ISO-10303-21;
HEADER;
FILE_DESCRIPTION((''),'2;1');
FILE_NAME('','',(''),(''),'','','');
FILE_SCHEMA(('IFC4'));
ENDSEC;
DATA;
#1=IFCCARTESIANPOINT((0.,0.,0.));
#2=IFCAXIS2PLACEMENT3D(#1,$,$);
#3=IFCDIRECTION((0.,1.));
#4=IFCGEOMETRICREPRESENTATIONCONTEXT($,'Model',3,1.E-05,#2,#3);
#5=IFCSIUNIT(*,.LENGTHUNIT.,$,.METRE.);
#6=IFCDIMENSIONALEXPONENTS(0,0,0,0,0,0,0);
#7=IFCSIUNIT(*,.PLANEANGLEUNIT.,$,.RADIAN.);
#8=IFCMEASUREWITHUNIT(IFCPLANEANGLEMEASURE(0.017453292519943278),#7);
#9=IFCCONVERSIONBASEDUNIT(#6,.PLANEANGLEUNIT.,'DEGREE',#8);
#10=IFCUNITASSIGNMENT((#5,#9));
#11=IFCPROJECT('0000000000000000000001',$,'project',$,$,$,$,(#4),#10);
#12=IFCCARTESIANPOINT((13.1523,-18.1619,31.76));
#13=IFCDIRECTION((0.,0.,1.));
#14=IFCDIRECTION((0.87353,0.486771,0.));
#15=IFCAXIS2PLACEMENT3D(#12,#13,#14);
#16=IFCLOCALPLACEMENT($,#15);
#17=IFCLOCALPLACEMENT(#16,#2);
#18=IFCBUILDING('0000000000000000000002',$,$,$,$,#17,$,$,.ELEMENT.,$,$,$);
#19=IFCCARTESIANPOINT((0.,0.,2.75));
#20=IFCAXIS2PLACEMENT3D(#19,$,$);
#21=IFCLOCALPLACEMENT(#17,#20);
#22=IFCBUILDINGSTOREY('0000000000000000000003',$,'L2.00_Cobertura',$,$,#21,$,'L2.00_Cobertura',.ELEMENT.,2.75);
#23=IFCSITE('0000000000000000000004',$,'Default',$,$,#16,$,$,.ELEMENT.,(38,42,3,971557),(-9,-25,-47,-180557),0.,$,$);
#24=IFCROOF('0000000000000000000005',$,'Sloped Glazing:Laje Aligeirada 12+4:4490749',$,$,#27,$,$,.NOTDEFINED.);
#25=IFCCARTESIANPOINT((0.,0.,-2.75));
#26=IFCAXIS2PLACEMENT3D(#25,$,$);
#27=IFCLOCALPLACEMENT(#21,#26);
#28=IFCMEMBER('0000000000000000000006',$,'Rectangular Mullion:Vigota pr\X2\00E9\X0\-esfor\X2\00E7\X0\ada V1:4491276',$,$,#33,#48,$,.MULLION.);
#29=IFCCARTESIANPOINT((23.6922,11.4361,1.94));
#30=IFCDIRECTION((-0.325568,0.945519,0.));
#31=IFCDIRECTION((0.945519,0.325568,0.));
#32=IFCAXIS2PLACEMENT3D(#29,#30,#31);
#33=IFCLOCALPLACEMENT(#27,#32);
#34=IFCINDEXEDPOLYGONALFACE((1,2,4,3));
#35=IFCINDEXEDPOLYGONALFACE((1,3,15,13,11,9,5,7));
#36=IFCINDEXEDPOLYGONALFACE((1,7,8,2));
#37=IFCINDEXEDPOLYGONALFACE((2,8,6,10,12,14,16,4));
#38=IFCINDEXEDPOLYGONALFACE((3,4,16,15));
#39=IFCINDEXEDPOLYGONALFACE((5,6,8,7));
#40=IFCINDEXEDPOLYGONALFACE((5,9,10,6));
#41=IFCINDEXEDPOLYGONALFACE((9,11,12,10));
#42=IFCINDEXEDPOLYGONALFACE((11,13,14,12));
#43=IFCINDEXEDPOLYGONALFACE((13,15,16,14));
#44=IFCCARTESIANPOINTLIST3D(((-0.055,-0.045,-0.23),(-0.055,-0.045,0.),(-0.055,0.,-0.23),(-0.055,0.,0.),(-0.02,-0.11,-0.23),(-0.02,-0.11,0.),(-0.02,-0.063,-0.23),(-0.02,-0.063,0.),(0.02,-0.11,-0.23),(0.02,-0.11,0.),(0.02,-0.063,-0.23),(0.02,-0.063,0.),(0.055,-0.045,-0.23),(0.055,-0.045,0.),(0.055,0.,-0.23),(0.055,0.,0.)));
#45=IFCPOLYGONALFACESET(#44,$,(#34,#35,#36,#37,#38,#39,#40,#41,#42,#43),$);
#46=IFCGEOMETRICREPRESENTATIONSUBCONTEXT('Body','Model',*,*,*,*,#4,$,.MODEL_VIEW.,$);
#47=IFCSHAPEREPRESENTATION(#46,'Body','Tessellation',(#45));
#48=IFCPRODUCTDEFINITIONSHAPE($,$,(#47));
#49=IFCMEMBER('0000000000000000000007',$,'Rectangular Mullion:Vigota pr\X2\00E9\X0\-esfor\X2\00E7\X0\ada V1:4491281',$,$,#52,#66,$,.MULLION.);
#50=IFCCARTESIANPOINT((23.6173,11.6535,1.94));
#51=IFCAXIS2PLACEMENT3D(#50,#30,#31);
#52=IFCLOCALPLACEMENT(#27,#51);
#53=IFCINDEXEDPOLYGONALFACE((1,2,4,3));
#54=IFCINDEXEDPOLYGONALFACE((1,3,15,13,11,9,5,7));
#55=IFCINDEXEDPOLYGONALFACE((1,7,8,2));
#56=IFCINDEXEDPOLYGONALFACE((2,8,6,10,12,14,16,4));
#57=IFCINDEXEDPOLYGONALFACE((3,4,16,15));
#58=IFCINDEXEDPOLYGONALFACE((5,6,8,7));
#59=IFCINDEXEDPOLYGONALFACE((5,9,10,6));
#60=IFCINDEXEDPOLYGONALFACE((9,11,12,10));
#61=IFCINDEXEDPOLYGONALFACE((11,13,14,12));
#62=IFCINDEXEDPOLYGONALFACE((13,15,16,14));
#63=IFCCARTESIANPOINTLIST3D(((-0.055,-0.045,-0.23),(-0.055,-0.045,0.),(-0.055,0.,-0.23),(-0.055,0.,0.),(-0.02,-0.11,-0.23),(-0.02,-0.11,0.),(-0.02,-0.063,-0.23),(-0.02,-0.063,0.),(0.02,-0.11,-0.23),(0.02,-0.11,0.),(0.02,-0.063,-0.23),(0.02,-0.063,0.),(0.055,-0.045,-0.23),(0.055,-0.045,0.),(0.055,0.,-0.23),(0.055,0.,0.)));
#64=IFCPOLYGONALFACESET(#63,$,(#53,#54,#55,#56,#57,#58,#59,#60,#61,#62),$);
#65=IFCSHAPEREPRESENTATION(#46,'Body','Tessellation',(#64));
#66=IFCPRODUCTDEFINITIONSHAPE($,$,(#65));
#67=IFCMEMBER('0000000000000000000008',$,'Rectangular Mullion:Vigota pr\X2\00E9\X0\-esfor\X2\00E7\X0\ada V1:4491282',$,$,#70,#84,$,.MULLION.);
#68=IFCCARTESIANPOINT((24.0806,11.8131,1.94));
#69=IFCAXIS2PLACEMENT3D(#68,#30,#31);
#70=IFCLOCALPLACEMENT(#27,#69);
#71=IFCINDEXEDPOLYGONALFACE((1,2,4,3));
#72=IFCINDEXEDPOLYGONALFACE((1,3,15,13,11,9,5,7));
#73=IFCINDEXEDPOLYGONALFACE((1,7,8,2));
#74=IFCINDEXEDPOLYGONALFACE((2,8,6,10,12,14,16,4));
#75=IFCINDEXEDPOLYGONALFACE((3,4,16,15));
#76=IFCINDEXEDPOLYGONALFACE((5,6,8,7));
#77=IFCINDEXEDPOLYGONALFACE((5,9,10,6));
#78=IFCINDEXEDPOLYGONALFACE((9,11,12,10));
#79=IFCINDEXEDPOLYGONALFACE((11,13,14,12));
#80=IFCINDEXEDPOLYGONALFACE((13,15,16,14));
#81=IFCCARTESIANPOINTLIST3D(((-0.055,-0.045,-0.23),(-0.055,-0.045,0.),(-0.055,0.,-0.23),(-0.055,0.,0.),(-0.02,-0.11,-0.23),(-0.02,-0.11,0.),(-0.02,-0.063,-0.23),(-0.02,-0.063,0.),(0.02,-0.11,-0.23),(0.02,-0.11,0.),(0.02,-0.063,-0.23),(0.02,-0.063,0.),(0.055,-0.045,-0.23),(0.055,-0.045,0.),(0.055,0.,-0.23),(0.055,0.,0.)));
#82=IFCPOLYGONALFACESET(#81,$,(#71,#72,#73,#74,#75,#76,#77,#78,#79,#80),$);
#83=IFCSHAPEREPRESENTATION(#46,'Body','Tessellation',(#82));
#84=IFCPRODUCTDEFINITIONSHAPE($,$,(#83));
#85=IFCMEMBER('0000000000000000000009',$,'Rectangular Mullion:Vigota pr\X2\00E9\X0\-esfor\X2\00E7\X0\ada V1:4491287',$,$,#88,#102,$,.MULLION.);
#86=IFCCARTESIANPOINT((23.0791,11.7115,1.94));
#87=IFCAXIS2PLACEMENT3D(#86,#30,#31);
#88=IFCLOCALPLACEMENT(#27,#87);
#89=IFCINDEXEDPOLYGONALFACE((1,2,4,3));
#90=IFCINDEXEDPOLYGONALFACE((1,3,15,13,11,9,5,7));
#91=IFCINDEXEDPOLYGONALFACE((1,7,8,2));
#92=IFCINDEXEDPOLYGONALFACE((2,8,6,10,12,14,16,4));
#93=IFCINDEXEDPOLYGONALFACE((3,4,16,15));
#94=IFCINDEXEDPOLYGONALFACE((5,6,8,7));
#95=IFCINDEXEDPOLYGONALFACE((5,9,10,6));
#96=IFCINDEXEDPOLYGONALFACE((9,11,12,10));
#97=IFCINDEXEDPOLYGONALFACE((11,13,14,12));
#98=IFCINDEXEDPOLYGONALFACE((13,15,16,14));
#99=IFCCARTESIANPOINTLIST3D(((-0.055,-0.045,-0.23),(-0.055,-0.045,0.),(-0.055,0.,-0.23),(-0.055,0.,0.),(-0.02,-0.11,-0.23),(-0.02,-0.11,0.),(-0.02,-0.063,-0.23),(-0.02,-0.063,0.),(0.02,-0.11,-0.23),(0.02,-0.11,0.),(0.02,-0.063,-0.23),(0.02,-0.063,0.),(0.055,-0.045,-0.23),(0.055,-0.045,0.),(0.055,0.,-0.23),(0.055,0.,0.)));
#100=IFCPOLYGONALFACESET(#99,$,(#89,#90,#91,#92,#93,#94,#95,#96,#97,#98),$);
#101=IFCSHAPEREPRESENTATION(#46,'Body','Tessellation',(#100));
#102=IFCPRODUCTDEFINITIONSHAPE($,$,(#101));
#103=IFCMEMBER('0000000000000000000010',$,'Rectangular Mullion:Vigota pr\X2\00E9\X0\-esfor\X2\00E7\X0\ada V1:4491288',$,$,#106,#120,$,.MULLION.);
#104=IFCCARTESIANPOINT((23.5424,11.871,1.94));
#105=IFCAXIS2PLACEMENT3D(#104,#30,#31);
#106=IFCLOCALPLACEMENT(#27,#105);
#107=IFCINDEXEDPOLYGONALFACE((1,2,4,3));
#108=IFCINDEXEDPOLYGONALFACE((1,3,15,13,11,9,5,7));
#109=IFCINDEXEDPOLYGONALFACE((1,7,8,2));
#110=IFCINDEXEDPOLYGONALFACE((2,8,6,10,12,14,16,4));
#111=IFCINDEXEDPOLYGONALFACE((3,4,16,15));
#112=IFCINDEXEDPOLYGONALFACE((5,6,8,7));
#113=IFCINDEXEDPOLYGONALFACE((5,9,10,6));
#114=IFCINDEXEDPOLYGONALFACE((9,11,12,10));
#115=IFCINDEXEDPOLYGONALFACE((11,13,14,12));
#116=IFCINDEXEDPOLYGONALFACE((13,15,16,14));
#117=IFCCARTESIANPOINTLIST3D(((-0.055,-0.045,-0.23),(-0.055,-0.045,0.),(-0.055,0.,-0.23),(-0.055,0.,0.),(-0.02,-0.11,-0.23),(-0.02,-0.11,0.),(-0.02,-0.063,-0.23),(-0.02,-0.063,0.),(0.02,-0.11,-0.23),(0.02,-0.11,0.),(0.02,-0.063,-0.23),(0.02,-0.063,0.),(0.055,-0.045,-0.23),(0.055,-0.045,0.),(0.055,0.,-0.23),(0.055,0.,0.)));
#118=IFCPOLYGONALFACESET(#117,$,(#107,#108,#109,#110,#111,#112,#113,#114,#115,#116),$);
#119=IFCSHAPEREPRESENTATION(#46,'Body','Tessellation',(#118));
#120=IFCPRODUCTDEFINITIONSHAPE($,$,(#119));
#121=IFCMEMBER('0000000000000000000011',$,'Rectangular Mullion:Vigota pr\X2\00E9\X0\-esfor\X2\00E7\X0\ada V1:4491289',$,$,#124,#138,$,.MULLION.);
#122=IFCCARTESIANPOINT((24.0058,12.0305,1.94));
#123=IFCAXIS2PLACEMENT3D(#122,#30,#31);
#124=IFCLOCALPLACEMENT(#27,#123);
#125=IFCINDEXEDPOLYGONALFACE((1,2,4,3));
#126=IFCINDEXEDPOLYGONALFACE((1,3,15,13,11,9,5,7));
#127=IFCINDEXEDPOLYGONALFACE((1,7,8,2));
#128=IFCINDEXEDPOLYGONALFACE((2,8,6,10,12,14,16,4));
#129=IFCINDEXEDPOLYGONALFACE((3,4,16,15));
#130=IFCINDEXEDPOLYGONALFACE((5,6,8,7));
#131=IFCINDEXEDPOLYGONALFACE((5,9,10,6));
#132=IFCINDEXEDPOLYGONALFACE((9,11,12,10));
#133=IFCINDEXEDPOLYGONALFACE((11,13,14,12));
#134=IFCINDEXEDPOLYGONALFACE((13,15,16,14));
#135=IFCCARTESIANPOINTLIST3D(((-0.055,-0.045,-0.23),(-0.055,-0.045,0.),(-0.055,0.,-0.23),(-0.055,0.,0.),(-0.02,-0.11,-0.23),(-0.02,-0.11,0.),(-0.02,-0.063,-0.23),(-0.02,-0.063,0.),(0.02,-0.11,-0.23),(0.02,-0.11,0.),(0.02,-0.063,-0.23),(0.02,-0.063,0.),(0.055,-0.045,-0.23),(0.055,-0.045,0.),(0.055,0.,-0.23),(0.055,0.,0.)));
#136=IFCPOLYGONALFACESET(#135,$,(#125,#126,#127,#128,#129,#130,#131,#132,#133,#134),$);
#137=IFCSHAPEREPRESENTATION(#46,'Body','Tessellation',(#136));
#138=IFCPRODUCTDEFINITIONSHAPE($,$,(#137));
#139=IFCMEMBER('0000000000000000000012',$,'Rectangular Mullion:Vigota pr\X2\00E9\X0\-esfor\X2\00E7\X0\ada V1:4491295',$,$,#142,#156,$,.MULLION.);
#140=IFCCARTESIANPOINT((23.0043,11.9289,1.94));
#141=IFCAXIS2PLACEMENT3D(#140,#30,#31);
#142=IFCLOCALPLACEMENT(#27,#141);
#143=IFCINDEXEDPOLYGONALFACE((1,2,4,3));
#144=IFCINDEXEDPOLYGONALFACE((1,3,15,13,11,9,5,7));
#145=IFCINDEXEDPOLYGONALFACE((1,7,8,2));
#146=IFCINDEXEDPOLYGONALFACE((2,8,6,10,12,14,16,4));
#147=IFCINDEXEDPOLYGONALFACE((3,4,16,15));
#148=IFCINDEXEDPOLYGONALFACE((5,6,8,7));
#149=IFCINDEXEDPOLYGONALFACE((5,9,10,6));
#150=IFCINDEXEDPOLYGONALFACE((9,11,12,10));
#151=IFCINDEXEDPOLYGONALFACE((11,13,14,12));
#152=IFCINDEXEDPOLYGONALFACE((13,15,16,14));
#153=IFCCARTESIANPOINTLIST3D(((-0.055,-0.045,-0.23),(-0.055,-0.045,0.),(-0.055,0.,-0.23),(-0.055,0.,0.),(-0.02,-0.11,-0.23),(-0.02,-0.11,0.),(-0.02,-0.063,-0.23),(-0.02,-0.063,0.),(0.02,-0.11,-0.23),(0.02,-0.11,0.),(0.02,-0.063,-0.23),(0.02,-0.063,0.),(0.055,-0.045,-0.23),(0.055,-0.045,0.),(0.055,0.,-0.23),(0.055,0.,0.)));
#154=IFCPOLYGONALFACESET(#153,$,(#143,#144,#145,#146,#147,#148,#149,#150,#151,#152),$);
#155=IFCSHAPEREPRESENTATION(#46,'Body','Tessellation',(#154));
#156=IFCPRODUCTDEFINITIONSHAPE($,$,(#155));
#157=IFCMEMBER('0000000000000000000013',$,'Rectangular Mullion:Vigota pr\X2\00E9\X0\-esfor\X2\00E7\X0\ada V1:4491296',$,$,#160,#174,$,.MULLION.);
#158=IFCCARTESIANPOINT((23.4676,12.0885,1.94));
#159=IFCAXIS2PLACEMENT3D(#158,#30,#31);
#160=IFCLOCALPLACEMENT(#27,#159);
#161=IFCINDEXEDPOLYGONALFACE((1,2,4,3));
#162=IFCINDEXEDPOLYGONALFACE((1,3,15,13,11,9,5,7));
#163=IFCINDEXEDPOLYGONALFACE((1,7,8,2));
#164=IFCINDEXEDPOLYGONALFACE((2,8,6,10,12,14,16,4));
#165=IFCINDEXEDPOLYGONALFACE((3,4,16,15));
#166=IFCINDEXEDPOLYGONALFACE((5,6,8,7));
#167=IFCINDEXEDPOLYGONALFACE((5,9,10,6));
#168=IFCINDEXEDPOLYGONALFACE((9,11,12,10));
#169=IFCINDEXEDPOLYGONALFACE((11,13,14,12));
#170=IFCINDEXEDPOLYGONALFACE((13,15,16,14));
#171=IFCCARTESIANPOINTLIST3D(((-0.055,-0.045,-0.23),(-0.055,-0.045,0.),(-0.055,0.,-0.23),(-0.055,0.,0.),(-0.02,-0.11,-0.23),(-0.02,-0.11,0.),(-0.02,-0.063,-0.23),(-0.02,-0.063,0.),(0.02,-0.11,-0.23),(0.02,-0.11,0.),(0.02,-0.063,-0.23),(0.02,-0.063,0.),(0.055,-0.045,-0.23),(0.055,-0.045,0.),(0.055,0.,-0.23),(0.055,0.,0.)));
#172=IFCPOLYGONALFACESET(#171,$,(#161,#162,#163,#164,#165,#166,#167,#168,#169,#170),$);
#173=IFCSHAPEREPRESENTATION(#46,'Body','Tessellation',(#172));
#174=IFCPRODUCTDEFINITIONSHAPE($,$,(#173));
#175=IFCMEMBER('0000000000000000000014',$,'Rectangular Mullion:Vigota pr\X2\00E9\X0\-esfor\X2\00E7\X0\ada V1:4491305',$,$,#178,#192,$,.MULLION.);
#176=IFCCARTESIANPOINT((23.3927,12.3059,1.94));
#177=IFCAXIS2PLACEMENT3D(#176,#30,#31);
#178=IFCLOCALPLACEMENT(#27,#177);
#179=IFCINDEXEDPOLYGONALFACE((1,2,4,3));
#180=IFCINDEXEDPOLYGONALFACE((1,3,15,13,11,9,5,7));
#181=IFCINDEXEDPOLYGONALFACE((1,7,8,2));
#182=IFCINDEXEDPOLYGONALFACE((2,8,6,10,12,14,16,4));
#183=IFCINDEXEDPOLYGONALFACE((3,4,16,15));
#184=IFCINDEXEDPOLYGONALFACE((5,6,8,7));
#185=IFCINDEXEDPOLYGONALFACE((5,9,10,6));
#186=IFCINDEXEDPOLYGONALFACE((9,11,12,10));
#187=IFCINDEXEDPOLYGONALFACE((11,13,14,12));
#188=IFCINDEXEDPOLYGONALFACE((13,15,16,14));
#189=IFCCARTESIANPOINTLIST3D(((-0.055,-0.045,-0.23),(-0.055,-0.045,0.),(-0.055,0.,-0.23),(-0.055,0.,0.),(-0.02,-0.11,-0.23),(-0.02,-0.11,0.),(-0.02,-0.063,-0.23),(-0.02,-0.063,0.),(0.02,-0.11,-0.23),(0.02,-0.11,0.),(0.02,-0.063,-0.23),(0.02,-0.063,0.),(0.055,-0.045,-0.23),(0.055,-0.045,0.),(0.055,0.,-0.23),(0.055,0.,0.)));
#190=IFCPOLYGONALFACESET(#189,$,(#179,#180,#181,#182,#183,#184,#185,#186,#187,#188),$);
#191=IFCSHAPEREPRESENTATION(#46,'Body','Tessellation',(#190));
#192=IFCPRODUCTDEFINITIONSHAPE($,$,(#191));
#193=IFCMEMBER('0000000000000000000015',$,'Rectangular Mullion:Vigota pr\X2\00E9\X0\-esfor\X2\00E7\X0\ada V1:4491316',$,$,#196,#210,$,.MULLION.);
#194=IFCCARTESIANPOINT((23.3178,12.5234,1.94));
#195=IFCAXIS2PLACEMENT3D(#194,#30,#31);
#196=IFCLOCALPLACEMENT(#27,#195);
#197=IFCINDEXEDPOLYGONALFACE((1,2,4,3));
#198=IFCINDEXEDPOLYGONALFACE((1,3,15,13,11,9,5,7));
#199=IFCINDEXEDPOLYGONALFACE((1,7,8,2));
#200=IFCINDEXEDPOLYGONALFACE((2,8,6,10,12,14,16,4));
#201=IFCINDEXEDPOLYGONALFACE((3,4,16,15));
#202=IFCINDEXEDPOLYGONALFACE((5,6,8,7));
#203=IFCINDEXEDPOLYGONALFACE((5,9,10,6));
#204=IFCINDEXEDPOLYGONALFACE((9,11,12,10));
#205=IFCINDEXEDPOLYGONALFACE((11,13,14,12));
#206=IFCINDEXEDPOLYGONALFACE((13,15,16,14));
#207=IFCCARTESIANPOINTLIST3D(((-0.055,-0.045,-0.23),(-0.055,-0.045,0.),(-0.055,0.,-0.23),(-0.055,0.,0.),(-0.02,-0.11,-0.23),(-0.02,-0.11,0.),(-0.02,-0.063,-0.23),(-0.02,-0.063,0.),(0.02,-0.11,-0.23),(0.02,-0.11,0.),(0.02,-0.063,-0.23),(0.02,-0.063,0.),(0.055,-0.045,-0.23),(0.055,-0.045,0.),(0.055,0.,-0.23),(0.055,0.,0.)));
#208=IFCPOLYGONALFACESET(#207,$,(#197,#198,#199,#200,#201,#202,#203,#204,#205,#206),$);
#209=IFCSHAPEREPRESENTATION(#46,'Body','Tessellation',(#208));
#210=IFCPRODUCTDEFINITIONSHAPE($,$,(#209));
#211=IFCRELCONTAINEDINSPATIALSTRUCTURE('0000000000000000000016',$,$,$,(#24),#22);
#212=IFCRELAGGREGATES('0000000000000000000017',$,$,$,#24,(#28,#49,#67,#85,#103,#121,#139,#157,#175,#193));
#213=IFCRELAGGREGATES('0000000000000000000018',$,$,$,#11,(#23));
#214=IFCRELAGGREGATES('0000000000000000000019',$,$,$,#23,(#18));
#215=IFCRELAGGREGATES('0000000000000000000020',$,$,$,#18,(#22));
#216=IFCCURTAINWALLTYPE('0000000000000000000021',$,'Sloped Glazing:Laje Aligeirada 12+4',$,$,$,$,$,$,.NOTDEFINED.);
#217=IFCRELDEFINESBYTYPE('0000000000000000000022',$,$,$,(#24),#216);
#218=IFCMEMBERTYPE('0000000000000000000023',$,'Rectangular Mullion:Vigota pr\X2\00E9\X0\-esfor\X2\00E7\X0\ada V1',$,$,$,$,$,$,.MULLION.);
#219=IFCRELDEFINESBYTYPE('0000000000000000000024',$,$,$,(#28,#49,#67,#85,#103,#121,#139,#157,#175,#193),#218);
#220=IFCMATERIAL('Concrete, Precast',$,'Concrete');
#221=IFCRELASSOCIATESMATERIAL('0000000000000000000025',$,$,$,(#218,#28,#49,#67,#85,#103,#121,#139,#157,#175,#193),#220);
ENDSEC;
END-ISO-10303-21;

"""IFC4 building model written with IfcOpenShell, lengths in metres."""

from ifc_helpers import new_model, entity, si_unit, converted_unit, direction, frame, origin, place, context, subcontext, project, spatial, indexed_curve, outline, extrude, source, transform, mapped, material, type_object, type_shapes, element, aggregate, save


model = new_model("IFC4")

# Units and contexts
model_context = context("Model", 3, precision=1e-05, world=origin(), true_north=direction((0.0, 1.0)))
body_context = subcontext(model_context, "Body", "Model", "MODEL_VIEW")
ifc_project = project(units=[si_unit("LENGTHUNIT", "METRE"), converted_unit("PLANEANGLEUNIT", "DEGREE", entity("IfcPlaneAngleMeasure", 0.017453292519943278), si_unit("PLANEANGLEUNIT", "RADIAN"), dimensions=[0, 0, 0, 0, 0, 0, 0])], contexts=[model_context])

# Site, building, storey
site_placement = place(None, frame((13.1523, -18.1619, 31.76), z_axis=(0.0, 0.0, 1.0), x_axis=(0.87353, 0.486771, 0.0)))
site = spatial("IfcSite", under=ifc_project, at=site_placement, Name="Default", CompositionType="ELEMENT", RefLatitude=(38, 42, 3, 971557), RefLongitude=(-9, -25, -47, -180557), RefElevation=0.0)
building_placement = place(site_placement, origin())
building = spatial("IfcBuilding", under=site, at=building_placement, CompositionType="ELEMENT")
storey_placement = place(building_placement, frame((0.0, 0.0, 2.75)))
storey = spatial("IfcBuildingStorey", under=building, at=storey_placement, Name="L2.00_Cobertura", LongName="L2.00_Cobertura", CompositionType="ELEMENT", Elevation=2.75)

# Roof, members
curtain_wall_type = type_object("IfcCurtainWallType", Name="Sloped Glazing:Laje Aligeirada 12+4", PredefinedType="NOTDEFINED")
roof_placement = place(storey_placement, frame((0.0, 0.0, -2.75)))
roof = element("IfcRoof", 1, at=roof_placement, inside=storey, type_object=curtain_wall_type, Name="Sloped Glazing:Laje Aligeirada 12+4:4490749", PredefinedType="NOTDEFINED")
ifc_material_1 = material(Name="Concrete, Precast", Category="Concrete")
member_type_1 = type_object("IfcMemberType", Name="Rectangular Mullion:Vigota pré-esforçada V1", PredefinedType="MULLION", material=ifc_material_1)
shared_shape_1 = source(origin(), body_context, "Body", "SweptSolid", [
    extrude(outline(indexed_curve([(-0.055, -0.0545), (0.055, -0.0545), (0.055, -0.0095), (0.02, 0.0085), (0.02, 0.0555), (-0.02, 0.0555), (-0.02, 0.0085), (-0.055, -0.0095), (-0.055, -0.0545)], self_intersect=False)), frame((0.0, -0.0545, -0.23), z_axis=(0.0, 0.0, 1.0), x_axis=(-1.0, 0.0, 0.0)), (0.0, 0.0, 1.0), 0.23),
])
type_shapes(member_type_1, [shared_shape_1])
member_1_placement = place(roof_placement, frame((23.6922, 11.4361, 1.94), z_axis=(-0.325568, 0.945519, 0.0), x_axis=(0.945519, 0.325568, 0.0)))
member_1 = element("IfcMember", 2, at=member_1_placement, type_object=member_type_1, material=ifc_material_1, Name="Rectangular Mullion:Vigota pré-esforçada V1:4491276", PredefinedType="MULLION", context=body_context, shape_type="MappedRepresentation", body=[
    mapped(shared_shape_1, transform((0.0, 0.0, 0.0), scale=1.0)),
])
member_2_placement = place(roof_placement, frame((23.6173, 11.6535, 1.94), z_axis=(-0.325568, 0.945519, 0.0), x_axis=(0.945519, 0.325568, 0.0)))
member_2 = element("IfcMember", 3, at=member_2_placement, type_object=member_type_1, material=ifc_material_1, Name="Rectangular Mullion:Vigota pré-esforçada V1:4491281", PredefinedType="MULLION", context=body_context, shape_type="MappedRepresentation", body=[
    mapped(shared_shape_1, transform((0.0, 0.0, 0.0), scale=1.0)),
])
member_3_placement = place(roof_placement, frame((24.0806, 11.8131, 1.94), z_axis=(-0.325568, 0.945519, 0.0), x_axis=(0.945519, 0.325568, 0.0)))
member_3 = element("IfcMember", 4, at=member_3_placement, type_object=member_type_1, material=ifc_material_1, Name="Rectangular Mullion:Vigota pré-esforçada V1:4491282", PredefinedType="MULLION", context=body_context, shape_type="MappedRepresentation", body=[
    mapped(shared_shape_1, transform((0.0, 0.0, 0.0), scale=1.0)),
])
member_4_placement = place(roof_placement, frame((23.0791, 11.7115, 1.94), z_axis=(-0.325568, 0.945519, 0.0), x_axis=(0.945519, 0.325568, 0.0)))
member_4 = element("IfcMember", 5, at=member_4_placement, type_object=member_type_1, material=ifc_material_1, Name="Rectangular Mullion:Vigota pré-esforçada V1:4491287", PredefinedType="MULLION", context=body_context, shape_type="MappedRepresentation", body=[
    mapped(shared_shape_1, transform((0.0, 0.0, 0.0), scale=1.0)),
])
member_5_placement = place(roof_placement, frame((23.5424, 11.871, 1.94), z_axis=(-0.325568, 0.945519, 0.0), x_axis=(0.945519, 0.325568, 0.0)))
member_5 = element("IfcMember", 6, at=member_5_placement, type_object=member_type_1, material=ifc_material_1, Name="Rectangular Mullion:Vigota pré-esforçada V1:4491288", PredefinedType="MULLION", context=body_context, shape_type="MappedRepresentation", body=[
    mapped(shared_shape_1, transform((0.0, 0.0, 0.0), scale=1.0)),
])
member_6_placement = place(roof_placement, frame((24.0058, 12.0305, 1.94), z_axis=(-0.325568, 0.945519, 0.0), x_axis=(0.945519, 0.325568, 0.0)))
member_6 = element("IfcMember", 7, at=member_6_placement, type_object=member_type_1, material=ifc_material_1, Name="Rectangular Mullion:Vigota pré-esforçada V1:4491289", PredefinedType="MULLION", context=body_context, shape_type="MappedRepresentation", body=[
    mapped(shared_shape_1, transform((0.0, 0.0, 0.0), scale=1.0)),
])
member_7_placement = place(roof_placement, frame((23.0043, 11.9289, 1.94), z_axis=(-0.325568, 0.945519, 0.0), x_axis=(0.945519, 0.325568, 0.0)))
member_7 = element("IfcMember", 8, at=member_7_placement, type_object=member_type_1, material=ifc_material_1, Name="Rectangular Mullion:Vigota pré-esforçada V1:4491295", PredefinedType="MULLION", context=body_context, shape_type="MappedRepresentation", body=[
    mapped(shared_shape_1, transform((0.0, 0.0, 0.0), scale=1.0)),
])
member_8_placement = place(roof_placement, frame((23.4676, 12.0885, 1.94), z_axis=(-0.325568, 0.945519, 0.0), x_axis=(0.945519, 0.325568, 0.0)))
member_8 = element("IfcMember", 9, at=member_8_placement, type_object=member_type_1, material=ifc_material_1, Name="Rectangular Mullion:Vigota pré-esforçada V1:4491296", PredefinedType="MULLION", context=body_context, shape_type="MappedRepresentation", body=[
    mapped(shared_shape_1, transform((0.0, 0.0, 0.0), scale=1.0)),
])
member_9_placement = place(roof_placement, frame((23.3927, 12.3059, 1.94), z_axis=(-0.325568, 0.945519, 0.0), x_axis=(0.945519, 0.325568, 0.0)))
member_9 = element("IfcMember", 10, at=member_9_placement, type_object=member_type_1, material=ifc_material_1, Name="Rectangular Mullion:Vigota pré-esforçada V1:4491305", PredefinedType="MULLION", context=body_context, shape_type="MappedRepresentation", body=[
    mapped(shared_shape_1, transform((0.0, 0.0, 0.0), scale=1.0)),
])
member_10_placement = place(roof_placement, frame((23.3178, 12.5234, 1.94), z_axis=(-0.325568, 0.945519, 0.0), x_axis=(0.945519, 0.325568, 0.0)))
member_10 = element("IfcMember", 11, at=member_10_placement, type_object=member_type_1, material=ifc_material_1, Name="Rectangular Mullion:Vigota pré-esforçada V1:4491316", PredefinedType="MULLION", context=body_context, shape_type="MappedRepresentation", body=[
    mapped(shared_shape_1, transform((0.0, 0.0, 0.0), scale=1.0)),
])
aggregate(roof, [member_1, member_2, member_3, member_4, member_5, member_6, member_7, member_8, member_9, member_10])

save(model, "model.ifc")
